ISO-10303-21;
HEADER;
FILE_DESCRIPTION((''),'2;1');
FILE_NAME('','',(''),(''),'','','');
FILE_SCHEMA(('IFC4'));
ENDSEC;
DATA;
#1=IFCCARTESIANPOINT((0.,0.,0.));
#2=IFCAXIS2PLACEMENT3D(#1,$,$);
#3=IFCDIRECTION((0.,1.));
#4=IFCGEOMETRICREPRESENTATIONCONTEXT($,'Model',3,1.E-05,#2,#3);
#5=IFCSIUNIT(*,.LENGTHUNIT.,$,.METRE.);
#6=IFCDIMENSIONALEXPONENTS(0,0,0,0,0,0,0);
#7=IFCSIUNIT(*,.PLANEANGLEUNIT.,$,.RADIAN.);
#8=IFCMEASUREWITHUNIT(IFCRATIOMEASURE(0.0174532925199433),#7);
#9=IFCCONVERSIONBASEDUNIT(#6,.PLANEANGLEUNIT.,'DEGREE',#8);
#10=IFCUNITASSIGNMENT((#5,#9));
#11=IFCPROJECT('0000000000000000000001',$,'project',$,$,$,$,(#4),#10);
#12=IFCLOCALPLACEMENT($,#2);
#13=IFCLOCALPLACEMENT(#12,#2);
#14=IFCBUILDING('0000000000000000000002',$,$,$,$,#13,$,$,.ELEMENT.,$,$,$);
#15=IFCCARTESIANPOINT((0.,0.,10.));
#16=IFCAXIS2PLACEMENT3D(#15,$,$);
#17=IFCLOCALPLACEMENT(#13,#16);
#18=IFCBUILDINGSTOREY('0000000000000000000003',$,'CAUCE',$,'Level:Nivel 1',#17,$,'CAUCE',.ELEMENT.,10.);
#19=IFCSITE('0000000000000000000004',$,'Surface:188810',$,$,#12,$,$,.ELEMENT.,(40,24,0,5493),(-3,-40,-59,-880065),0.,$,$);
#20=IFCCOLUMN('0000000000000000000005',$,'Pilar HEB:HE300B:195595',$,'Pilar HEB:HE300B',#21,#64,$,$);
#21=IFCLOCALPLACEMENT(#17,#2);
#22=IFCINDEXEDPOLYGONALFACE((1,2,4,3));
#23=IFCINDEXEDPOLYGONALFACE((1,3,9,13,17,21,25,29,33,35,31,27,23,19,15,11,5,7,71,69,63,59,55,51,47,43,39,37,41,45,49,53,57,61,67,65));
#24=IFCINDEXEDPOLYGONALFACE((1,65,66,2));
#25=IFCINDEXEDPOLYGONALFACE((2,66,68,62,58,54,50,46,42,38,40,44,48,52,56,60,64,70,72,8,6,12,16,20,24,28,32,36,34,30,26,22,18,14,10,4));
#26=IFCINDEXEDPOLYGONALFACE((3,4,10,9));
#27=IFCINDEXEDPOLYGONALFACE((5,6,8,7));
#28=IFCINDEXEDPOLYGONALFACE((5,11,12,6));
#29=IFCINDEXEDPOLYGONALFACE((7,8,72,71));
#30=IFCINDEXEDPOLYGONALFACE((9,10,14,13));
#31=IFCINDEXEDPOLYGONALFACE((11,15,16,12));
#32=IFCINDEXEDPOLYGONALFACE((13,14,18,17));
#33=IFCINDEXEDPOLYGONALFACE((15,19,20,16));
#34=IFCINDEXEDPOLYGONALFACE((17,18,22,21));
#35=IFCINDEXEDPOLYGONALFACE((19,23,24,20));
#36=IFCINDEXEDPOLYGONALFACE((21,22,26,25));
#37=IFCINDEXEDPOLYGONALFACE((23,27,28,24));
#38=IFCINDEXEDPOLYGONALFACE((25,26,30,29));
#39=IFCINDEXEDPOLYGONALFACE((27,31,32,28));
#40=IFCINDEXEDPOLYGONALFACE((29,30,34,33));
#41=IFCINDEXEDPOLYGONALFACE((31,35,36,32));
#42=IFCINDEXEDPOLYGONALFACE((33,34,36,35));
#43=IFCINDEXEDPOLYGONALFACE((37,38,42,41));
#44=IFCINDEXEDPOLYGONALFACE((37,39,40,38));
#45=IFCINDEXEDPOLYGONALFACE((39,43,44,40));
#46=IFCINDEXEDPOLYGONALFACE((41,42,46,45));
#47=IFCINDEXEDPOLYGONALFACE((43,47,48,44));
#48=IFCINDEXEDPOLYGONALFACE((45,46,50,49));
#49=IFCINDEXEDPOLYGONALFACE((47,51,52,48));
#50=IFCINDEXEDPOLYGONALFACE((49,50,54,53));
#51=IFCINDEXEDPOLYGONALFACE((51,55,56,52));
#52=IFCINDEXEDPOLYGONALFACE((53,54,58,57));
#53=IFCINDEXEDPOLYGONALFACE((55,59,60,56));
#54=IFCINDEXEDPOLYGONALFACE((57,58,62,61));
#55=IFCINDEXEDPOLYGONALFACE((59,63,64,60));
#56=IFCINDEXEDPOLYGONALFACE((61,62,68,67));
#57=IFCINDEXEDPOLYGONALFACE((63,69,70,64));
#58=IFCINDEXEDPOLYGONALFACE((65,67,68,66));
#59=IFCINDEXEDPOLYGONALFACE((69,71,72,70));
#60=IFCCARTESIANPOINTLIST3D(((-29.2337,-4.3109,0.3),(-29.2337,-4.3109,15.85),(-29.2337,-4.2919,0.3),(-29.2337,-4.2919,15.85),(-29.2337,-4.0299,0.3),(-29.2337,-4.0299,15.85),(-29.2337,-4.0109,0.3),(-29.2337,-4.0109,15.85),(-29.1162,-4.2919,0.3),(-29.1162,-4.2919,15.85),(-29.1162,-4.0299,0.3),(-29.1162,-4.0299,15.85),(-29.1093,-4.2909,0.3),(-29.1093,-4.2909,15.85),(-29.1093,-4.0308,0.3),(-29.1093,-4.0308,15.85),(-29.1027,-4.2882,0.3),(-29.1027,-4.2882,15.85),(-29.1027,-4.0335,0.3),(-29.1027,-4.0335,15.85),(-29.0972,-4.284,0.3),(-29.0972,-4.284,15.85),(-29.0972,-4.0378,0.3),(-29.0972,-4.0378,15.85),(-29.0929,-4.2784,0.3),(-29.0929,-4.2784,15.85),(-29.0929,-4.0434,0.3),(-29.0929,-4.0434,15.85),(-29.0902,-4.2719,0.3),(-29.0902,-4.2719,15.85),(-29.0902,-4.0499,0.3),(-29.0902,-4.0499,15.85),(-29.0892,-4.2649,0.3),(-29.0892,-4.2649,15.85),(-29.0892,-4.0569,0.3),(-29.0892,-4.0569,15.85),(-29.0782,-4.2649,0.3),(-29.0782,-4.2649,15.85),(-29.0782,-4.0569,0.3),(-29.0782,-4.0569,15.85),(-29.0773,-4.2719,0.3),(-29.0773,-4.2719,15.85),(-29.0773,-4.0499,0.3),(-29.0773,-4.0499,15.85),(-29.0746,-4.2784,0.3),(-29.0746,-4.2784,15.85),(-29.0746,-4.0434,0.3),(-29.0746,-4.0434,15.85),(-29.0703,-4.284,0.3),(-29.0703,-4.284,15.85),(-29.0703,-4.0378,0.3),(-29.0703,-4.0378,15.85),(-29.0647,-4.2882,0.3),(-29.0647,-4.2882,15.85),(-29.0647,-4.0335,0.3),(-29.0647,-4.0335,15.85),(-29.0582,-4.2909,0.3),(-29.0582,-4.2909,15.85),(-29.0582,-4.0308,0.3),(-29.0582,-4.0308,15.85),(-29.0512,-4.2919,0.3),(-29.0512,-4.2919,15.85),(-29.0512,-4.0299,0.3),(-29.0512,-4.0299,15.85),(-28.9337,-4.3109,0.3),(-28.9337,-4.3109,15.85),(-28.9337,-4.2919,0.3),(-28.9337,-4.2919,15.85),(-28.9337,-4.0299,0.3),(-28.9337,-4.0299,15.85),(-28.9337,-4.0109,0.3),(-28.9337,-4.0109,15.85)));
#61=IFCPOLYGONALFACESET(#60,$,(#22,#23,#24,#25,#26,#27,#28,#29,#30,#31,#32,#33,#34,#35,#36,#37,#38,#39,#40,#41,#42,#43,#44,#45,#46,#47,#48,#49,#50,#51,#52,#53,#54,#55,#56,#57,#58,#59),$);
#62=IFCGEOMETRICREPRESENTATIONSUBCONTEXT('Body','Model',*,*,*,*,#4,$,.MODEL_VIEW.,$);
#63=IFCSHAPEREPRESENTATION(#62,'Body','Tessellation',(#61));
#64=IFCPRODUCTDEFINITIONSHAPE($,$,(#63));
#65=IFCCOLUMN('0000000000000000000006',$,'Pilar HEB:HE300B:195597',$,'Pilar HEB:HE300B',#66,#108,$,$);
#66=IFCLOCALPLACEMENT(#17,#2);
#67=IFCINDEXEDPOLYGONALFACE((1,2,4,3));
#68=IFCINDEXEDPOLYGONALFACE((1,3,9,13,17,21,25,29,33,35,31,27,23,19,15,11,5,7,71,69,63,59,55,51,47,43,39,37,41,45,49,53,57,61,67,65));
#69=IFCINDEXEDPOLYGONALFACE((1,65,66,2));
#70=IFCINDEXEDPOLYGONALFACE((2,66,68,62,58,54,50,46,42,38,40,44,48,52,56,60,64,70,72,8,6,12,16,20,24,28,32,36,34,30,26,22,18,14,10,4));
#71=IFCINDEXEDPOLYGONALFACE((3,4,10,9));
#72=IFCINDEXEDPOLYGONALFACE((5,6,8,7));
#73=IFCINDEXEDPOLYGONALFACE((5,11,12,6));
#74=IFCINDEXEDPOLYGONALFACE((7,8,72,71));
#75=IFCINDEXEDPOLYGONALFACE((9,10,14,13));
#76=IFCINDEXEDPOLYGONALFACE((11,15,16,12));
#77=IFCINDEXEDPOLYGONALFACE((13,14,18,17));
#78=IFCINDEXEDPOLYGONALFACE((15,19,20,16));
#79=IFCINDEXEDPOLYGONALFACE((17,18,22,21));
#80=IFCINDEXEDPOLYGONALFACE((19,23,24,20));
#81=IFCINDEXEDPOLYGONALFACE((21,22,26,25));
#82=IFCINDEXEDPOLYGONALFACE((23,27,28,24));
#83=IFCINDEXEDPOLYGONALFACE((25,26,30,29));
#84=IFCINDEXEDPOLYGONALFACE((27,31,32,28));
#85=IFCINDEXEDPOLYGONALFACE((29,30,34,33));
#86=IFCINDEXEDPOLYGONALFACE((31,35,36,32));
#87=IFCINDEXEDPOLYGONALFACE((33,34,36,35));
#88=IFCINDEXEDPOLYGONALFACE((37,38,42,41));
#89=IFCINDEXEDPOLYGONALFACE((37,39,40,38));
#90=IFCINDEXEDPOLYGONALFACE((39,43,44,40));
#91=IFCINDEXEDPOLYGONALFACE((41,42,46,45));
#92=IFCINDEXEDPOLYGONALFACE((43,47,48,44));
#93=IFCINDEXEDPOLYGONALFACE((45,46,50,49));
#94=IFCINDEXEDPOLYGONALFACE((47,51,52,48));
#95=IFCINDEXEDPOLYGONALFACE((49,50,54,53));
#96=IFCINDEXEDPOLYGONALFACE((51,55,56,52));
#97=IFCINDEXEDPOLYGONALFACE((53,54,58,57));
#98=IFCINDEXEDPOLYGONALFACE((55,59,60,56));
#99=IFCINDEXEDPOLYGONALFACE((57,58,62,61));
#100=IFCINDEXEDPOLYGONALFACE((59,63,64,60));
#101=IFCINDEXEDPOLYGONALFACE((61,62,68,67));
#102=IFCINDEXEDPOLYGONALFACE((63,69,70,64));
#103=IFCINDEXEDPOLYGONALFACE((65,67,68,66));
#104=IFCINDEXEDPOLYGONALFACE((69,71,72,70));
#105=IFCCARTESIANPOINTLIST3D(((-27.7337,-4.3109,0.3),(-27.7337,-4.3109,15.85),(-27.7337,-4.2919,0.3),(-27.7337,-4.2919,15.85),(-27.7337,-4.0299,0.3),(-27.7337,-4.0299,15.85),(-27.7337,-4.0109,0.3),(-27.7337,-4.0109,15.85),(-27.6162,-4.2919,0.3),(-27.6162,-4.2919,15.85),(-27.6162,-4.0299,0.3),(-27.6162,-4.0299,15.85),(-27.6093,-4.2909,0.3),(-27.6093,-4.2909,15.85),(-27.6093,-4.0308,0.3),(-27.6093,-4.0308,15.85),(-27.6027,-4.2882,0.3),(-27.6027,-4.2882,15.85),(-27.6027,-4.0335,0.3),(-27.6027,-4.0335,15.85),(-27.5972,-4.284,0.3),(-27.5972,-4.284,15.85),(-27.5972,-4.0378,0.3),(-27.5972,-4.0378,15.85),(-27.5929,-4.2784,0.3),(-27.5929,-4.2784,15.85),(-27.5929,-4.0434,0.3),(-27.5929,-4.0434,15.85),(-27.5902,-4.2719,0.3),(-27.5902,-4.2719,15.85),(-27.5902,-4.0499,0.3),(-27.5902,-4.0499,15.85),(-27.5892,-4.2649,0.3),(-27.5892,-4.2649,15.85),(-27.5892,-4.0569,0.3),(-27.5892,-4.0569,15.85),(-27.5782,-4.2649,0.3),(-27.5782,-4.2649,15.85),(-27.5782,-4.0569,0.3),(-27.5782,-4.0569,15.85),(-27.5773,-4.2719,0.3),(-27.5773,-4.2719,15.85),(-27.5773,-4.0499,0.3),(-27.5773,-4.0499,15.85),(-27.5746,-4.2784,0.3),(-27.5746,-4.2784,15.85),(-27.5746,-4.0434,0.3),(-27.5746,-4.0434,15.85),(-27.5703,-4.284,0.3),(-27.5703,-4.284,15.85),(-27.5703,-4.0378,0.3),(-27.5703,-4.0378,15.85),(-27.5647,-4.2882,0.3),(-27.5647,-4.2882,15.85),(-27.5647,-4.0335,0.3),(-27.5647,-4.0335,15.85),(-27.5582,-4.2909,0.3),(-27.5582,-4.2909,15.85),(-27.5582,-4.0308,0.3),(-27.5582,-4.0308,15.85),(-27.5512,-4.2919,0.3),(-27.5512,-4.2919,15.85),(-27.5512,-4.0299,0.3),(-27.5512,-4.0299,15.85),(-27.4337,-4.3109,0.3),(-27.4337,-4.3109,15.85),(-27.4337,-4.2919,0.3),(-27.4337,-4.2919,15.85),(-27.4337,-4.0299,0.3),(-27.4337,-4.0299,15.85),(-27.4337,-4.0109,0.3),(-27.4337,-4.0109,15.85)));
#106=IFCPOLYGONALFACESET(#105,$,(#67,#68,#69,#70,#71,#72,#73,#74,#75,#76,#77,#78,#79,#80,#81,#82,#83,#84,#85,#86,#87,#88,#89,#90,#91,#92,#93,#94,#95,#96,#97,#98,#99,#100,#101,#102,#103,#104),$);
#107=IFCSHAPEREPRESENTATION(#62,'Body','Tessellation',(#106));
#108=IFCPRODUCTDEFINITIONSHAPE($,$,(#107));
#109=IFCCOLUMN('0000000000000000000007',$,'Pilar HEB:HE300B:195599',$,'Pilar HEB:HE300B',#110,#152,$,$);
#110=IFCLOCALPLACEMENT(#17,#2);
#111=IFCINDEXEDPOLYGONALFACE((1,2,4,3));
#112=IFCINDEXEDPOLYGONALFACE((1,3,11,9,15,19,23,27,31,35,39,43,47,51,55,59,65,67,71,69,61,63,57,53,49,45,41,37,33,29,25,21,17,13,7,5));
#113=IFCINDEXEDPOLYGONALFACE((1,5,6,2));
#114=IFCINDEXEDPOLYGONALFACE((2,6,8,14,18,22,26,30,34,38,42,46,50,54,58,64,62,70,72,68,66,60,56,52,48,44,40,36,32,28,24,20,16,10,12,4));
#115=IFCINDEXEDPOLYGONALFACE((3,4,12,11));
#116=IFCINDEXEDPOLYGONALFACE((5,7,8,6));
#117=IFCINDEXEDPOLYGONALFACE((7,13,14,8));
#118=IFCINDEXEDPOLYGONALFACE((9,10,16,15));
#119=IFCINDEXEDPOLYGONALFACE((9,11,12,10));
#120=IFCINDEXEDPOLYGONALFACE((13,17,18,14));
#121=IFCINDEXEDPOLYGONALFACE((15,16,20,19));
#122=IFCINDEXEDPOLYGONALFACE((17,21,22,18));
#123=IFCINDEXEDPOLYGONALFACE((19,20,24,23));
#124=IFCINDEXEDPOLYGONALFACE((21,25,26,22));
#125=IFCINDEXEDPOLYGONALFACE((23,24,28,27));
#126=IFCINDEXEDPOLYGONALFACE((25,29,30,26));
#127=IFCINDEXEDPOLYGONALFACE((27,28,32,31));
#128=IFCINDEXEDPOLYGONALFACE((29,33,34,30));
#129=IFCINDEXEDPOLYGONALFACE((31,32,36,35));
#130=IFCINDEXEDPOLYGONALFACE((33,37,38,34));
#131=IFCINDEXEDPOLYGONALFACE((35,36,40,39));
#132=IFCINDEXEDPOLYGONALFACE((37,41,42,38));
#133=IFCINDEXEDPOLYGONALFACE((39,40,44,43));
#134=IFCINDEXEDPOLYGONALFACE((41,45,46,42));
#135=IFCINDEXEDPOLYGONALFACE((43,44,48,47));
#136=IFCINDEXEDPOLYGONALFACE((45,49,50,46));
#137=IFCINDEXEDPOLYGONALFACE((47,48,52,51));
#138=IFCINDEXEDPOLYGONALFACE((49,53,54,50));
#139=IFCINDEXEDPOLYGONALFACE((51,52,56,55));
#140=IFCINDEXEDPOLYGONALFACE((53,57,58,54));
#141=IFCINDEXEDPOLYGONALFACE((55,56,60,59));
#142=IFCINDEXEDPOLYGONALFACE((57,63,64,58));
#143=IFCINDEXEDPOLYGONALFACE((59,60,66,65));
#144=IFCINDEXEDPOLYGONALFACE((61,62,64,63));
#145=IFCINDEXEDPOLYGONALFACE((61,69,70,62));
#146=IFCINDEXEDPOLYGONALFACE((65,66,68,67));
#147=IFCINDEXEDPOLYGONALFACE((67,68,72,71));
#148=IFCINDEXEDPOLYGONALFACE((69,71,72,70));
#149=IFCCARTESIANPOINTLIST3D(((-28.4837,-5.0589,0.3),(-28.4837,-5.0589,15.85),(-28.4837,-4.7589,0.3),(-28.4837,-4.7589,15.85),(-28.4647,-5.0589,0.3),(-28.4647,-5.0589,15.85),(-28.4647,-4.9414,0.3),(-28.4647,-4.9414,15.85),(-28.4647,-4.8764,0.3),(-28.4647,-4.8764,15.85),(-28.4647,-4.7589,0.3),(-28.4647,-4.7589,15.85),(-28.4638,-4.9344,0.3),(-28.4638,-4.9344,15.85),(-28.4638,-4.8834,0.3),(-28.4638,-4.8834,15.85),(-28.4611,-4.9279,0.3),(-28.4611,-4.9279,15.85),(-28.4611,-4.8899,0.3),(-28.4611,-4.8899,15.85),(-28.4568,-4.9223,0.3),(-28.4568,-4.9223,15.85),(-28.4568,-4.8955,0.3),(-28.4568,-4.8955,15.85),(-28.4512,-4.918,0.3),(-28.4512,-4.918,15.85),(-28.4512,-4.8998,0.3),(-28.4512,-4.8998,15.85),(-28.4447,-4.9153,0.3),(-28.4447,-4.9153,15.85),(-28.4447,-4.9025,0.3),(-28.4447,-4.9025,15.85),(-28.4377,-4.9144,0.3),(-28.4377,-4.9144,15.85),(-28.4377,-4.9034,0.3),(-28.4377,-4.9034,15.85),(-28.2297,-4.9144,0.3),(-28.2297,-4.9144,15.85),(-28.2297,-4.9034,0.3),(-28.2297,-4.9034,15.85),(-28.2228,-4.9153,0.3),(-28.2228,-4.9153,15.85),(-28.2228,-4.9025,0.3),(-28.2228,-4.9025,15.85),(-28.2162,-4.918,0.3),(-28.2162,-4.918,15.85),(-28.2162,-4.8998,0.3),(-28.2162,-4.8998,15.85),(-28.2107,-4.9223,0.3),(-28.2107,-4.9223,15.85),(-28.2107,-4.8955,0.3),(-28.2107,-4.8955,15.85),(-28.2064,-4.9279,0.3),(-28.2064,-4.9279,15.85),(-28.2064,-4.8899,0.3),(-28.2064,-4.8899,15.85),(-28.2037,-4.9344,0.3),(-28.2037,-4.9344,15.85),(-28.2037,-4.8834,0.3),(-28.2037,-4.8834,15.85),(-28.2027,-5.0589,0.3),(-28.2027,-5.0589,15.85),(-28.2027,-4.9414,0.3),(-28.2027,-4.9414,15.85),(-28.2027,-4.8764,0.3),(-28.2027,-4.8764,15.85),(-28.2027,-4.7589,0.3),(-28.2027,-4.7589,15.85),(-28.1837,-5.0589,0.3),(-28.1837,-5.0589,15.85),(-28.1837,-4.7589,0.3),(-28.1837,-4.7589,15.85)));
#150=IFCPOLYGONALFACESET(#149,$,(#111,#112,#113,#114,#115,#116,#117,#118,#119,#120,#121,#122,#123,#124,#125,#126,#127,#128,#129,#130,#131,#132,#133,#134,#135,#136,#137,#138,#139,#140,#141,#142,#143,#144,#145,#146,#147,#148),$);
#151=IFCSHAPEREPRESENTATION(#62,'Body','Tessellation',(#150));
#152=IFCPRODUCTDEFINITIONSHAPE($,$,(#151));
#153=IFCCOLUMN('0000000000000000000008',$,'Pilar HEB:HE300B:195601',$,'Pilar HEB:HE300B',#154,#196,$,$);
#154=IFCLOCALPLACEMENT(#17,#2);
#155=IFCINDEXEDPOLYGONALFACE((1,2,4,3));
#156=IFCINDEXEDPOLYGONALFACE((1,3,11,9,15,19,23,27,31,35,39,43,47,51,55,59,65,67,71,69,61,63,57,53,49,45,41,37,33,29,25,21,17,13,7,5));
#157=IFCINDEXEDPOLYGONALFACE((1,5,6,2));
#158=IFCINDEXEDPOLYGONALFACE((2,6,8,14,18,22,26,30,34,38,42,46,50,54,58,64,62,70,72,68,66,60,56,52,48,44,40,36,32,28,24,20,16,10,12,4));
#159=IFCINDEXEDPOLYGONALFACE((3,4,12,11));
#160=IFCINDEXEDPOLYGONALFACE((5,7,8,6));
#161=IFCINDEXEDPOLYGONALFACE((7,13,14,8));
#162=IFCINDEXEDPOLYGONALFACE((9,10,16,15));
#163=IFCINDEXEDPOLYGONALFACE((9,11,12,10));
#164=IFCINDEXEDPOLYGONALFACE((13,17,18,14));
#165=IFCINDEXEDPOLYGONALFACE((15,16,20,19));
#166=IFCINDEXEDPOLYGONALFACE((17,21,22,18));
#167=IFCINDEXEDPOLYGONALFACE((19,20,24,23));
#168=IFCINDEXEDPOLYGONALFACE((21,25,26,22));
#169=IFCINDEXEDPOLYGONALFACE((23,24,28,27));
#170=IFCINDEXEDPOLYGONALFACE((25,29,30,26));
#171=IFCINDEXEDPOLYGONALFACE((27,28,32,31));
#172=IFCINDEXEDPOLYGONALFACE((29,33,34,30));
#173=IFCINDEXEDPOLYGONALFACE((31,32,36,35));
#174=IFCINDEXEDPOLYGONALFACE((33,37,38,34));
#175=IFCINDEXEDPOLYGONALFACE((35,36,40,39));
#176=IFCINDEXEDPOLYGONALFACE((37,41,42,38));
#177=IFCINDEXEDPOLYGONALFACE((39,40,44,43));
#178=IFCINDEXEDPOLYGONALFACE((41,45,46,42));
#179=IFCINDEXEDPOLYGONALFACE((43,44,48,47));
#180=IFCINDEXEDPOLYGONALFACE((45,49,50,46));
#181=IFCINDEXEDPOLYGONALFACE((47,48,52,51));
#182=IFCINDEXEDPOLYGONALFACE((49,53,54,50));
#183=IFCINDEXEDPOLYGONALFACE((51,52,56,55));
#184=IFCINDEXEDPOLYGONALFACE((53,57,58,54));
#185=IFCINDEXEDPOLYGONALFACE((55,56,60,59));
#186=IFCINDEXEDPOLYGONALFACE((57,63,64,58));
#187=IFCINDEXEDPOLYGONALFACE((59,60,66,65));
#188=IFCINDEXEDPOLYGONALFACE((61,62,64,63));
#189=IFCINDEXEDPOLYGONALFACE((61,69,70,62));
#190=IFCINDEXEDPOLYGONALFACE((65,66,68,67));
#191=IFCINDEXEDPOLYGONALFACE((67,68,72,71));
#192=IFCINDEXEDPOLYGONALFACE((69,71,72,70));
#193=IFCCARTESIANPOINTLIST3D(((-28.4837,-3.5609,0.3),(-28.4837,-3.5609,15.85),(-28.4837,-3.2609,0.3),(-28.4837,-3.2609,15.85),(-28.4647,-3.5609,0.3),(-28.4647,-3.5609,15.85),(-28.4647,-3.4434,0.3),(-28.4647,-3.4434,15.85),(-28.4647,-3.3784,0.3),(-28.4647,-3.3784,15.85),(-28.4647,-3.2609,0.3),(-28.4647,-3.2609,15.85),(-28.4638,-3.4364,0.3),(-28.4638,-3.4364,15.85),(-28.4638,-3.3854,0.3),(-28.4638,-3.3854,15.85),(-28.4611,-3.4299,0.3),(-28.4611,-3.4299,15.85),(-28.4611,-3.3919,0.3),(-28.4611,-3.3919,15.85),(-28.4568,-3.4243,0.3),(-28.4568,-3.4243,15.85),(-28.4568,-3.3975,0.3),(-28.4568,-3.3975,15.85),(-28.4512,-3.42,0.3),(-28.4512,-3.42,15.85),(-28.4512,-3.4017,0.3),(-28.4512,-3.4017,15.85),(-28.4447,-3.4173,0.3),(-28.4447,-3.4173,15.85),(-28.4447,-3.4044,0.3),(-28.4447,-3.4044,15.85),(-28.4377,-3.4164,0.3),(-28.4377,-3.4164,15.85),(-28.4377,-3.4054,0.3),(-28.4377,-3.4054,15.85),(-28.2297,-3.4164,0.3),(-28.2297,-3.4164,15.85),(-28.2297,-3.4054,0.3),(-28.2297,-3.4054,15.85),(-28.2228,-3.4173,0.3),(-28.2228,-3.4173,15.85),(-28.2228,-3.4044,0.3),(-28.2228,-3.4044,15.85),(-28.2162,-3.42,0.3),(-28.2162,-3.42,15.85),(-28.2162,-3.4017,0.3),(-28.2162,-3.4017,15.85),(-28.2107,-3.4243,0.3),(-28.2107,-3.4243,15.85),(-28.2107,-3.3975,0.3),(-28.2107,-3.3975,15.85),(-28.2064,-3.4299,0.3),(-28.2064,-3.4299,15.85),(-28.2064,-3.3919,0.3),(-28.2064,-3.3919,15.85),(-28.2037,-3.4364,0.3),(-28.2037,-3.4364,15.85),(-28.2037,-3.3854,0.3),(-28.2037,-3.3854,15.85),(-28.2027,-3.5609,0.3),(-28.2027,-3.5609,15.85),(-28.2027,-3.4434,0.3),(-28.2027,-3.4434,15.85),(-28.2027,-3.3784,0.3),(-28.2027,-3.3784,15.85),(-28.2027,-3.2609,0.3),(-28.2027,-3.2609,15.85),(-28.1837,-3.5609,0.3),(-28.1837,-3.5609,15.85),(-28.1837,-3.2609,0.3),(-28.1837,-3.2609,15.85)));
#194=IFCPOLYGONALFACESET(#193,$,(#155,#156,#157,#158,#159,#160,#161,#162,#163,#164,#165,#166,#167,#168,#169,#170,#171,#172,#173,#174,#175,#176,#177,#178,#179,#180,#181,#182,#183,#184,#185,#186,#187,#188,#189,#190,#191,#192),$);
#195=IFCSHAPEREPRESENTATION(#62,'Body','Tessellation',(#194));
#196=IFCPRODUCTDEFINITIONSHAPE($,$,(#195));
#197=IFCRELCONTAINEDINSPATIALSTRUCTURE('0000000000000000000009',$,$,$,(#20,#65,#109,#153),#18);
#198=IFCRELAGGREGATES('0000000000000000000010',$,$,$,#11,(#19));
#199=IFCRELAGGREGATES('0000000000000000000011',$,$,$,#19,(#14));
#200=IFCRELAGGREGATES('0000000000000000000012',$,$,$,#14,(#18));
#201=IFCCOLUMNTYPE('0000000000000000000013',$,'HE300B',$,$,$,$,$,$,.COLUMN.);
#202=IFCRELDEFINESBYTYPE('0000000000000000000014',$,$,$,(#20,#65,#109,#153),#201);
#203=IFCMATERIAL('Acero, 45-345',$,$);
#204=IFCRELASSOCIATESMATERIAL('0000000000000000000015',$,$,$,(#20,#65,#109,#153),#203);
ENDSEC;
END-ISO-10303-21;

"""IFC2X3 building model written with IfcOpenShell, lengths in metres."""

from ifc_helpers import new_model, entity, si_unit, converted_unit, direction, frame, frame_2d, origin, place, context, subcontext, project, spatial, polyline, circle_curve, parameter, trimmed, segment, composite_curve, outline, extrude, source, transform, mapped, material, type_object, type_shapes, element, save


model = new_model("IFC2X3")

# Units and contexts
model_context = context("Model", 3, precision=1e-05, world=origin(), true_north=direction((0.0, 1.0)))
body_context = subcontext(model_context, "Body", "Model", "MODEL_VIEW")
ifc_project = project(units=[si_unit("LENGTHUNIT", "METRE"), converted_unit("PLANEANGLEUNIT", "DEGREE", entity("IfcRatioMeasure", 0.0174532925199433), si_unit("PLANEANGLEUNIT", "RADIAN"), dimensions=[0, 0, 0, 0, 0, 0, 0])], contexts=[model_context])

# Site, building, storey
site_placement = place(None, origin())
site = spatial("IfcSite", under=ifc_project, at=site_placement, Name="Surface:188810", CompositionType="ELEMENT", RefLatitude=(40, 24, 0, 5493), RefLongitude=(-3, -40, -59, -880065), RefElevation=0.0)
building_placement = place(site_placement, origin())
building = spatial("IfcBuilding", under=site, at=building_placement, CompositionType="ELEMENT")
storey_placement = place(building_placement, frame((0.0, 0.0, 10.0)))
storey = spatial("IfcBuildingStorey", under=building, at=storey_placement, Name="CAUCE", ObjectType="Level:Nivel 1", LongName="CAUCE", CompositionType="ELEMENT", Elevation=10.0)

# Columns
ifc_material_1 = material(Name="Acero, 45-345")
column_type_1 = type_object("IfcColumnType", Name="HE300B", PredefinedType="COLUMN")
shared_shape_1 = source(origin(), body_context, "Body", "SweptSolid", [
    extrude(outline(composite_curve([segment(polyline([(0.131, -0.15), (0.15, -0.15)]), True, "CONTINUOUS"), segment(polyline([(0.15, -0.15), (0.15, 0.15)]), True, "CONTINUOUS"), segment(polyline([(0.15, 0.15), (0.131, 0.15)]), True, "CONTINUOUS"), segment(polyline([(0.131, 0.15), (0.131, 0.0325)]), True, "CONTINUOUS"), segment(trimmed(circle_curve(frame_2d((0.104, 0.0325), x_axis=(1.0, 0.0)), 0.027), [parameter(270.0)], [parameter(0.0)], True, "PARAMETER"), False, "CONTINUOUS"), segment(polyline([(0.104, 0.0055), (-0.104, 0.0055)]), True, "CONTINUOUS"), segment(trimmed(circle_curve(frame_2d((-0.104, 0.0325), x_axis=(0.0, -1.0)), 0.027), [parameter(270.0)], [parameter(0.0)], True, "PARAMETER"), False, "CONTINUOUS"), segment(polyline([(-0.131, 0.0325), (-0.131, 0.15)]), True, "CONTINUOUS"), segment(polyline([(-0.131, 0.15), (-0.15, 0.15)]), True, "CONTINUOUS"), segment(polyline([(-0.15, 0.15), (-0.15, -0.15)]), True, "CONTINUOUS"), segment(polyline([(-0.15, -0.15), (-0.131, -0.15)]), True, "CONTINUOUS"), segment(polyline([(-0.131, -0.15), (-0.131, -0.0325)]), True, "CONTINUOUS"), segment(trimmed(circle_curve(frame_2d((-0.104, -0.0325), x_axis=(-1.0, 0.0)), 0.027), [parameter(270.0)], [parameter(0.0)], True, "PARAMETER"), False, "CONTINUOUS"), segment(polyline([(-0.104, -0.0055), (0.104, -0.0055)]), True, "CONTINUOUS"), segment(trimmed(circle_curve(frame_2d((0.104, -0.0325), x_axis=(0.0, 1.0)), 0.027), [parameter(270.0)], [parameter(0.0)], True, "PARAMETER"), False, "CONTINUOUS"), segment(polyline([(0.131, -0.0325), (0.131, -0.15)]), True, "CONTINUOUS")], self_intersect=False)), frame((0.0, 0.0, 10.3), z_axis=(0.0, 0.0, 1.0), x_axis=(0.0, -1.0, 0.0)), (0.0, 0.0, 1.0), 15.55),
])
type_shapes(column_type_1, [shared_shape_1])
for number, where, name in (
    (1, (-29.0837, -4.1609, -10.0), "Pilar HEB:HE300B:195595"),
    (2, (-27.5837, -4.1609, -10.0), "Pilar HEB:HE300B:195597"),
):
    element("IfcColumn", number, at=place(storey_placement, frame(where)), inside=storey, type_object=column_type_1, material=ifc_material_1, Name=name, ObjectType="Pilar HEB:HE300B", context=body_context, shape_type="MappedRepresentation", body=[
        mapped(shared_shape_1, transform((0.0, 0.0, 0.0), scale=1.0)),
    ])
for number, where, z_axis, x_axis, name in (
    (3, (-28.3337, -4.9089, -10.0), (0.0, 0.0, 1.0), (0.0, -1.0, 0.0), "Pilar HEB:HE300B:195599"),
    (4, (-28.3337, -3.4109, -10.0), (0.0, 0.0, 1.0), (0.0, -1.0, 0.0), "Pilar HEB:HE300B:195601"),
):
    element("IfcColumn", number, at=place(storey_placement, frame(where, z_axis=z_axis, x_axis=x_axis)), inside=storey, type_object=column_type_1, material=ifc_material_1, Name=name, ObjectType="Pilar HEB:HE300B", context=body_context, shape_type="MappedRepresentation", body=[
        mapped(shared_shape_1, transform((0.0, 0.0, 0.0), scale=1.0)),
    ])

save(model, "model.ifc")
